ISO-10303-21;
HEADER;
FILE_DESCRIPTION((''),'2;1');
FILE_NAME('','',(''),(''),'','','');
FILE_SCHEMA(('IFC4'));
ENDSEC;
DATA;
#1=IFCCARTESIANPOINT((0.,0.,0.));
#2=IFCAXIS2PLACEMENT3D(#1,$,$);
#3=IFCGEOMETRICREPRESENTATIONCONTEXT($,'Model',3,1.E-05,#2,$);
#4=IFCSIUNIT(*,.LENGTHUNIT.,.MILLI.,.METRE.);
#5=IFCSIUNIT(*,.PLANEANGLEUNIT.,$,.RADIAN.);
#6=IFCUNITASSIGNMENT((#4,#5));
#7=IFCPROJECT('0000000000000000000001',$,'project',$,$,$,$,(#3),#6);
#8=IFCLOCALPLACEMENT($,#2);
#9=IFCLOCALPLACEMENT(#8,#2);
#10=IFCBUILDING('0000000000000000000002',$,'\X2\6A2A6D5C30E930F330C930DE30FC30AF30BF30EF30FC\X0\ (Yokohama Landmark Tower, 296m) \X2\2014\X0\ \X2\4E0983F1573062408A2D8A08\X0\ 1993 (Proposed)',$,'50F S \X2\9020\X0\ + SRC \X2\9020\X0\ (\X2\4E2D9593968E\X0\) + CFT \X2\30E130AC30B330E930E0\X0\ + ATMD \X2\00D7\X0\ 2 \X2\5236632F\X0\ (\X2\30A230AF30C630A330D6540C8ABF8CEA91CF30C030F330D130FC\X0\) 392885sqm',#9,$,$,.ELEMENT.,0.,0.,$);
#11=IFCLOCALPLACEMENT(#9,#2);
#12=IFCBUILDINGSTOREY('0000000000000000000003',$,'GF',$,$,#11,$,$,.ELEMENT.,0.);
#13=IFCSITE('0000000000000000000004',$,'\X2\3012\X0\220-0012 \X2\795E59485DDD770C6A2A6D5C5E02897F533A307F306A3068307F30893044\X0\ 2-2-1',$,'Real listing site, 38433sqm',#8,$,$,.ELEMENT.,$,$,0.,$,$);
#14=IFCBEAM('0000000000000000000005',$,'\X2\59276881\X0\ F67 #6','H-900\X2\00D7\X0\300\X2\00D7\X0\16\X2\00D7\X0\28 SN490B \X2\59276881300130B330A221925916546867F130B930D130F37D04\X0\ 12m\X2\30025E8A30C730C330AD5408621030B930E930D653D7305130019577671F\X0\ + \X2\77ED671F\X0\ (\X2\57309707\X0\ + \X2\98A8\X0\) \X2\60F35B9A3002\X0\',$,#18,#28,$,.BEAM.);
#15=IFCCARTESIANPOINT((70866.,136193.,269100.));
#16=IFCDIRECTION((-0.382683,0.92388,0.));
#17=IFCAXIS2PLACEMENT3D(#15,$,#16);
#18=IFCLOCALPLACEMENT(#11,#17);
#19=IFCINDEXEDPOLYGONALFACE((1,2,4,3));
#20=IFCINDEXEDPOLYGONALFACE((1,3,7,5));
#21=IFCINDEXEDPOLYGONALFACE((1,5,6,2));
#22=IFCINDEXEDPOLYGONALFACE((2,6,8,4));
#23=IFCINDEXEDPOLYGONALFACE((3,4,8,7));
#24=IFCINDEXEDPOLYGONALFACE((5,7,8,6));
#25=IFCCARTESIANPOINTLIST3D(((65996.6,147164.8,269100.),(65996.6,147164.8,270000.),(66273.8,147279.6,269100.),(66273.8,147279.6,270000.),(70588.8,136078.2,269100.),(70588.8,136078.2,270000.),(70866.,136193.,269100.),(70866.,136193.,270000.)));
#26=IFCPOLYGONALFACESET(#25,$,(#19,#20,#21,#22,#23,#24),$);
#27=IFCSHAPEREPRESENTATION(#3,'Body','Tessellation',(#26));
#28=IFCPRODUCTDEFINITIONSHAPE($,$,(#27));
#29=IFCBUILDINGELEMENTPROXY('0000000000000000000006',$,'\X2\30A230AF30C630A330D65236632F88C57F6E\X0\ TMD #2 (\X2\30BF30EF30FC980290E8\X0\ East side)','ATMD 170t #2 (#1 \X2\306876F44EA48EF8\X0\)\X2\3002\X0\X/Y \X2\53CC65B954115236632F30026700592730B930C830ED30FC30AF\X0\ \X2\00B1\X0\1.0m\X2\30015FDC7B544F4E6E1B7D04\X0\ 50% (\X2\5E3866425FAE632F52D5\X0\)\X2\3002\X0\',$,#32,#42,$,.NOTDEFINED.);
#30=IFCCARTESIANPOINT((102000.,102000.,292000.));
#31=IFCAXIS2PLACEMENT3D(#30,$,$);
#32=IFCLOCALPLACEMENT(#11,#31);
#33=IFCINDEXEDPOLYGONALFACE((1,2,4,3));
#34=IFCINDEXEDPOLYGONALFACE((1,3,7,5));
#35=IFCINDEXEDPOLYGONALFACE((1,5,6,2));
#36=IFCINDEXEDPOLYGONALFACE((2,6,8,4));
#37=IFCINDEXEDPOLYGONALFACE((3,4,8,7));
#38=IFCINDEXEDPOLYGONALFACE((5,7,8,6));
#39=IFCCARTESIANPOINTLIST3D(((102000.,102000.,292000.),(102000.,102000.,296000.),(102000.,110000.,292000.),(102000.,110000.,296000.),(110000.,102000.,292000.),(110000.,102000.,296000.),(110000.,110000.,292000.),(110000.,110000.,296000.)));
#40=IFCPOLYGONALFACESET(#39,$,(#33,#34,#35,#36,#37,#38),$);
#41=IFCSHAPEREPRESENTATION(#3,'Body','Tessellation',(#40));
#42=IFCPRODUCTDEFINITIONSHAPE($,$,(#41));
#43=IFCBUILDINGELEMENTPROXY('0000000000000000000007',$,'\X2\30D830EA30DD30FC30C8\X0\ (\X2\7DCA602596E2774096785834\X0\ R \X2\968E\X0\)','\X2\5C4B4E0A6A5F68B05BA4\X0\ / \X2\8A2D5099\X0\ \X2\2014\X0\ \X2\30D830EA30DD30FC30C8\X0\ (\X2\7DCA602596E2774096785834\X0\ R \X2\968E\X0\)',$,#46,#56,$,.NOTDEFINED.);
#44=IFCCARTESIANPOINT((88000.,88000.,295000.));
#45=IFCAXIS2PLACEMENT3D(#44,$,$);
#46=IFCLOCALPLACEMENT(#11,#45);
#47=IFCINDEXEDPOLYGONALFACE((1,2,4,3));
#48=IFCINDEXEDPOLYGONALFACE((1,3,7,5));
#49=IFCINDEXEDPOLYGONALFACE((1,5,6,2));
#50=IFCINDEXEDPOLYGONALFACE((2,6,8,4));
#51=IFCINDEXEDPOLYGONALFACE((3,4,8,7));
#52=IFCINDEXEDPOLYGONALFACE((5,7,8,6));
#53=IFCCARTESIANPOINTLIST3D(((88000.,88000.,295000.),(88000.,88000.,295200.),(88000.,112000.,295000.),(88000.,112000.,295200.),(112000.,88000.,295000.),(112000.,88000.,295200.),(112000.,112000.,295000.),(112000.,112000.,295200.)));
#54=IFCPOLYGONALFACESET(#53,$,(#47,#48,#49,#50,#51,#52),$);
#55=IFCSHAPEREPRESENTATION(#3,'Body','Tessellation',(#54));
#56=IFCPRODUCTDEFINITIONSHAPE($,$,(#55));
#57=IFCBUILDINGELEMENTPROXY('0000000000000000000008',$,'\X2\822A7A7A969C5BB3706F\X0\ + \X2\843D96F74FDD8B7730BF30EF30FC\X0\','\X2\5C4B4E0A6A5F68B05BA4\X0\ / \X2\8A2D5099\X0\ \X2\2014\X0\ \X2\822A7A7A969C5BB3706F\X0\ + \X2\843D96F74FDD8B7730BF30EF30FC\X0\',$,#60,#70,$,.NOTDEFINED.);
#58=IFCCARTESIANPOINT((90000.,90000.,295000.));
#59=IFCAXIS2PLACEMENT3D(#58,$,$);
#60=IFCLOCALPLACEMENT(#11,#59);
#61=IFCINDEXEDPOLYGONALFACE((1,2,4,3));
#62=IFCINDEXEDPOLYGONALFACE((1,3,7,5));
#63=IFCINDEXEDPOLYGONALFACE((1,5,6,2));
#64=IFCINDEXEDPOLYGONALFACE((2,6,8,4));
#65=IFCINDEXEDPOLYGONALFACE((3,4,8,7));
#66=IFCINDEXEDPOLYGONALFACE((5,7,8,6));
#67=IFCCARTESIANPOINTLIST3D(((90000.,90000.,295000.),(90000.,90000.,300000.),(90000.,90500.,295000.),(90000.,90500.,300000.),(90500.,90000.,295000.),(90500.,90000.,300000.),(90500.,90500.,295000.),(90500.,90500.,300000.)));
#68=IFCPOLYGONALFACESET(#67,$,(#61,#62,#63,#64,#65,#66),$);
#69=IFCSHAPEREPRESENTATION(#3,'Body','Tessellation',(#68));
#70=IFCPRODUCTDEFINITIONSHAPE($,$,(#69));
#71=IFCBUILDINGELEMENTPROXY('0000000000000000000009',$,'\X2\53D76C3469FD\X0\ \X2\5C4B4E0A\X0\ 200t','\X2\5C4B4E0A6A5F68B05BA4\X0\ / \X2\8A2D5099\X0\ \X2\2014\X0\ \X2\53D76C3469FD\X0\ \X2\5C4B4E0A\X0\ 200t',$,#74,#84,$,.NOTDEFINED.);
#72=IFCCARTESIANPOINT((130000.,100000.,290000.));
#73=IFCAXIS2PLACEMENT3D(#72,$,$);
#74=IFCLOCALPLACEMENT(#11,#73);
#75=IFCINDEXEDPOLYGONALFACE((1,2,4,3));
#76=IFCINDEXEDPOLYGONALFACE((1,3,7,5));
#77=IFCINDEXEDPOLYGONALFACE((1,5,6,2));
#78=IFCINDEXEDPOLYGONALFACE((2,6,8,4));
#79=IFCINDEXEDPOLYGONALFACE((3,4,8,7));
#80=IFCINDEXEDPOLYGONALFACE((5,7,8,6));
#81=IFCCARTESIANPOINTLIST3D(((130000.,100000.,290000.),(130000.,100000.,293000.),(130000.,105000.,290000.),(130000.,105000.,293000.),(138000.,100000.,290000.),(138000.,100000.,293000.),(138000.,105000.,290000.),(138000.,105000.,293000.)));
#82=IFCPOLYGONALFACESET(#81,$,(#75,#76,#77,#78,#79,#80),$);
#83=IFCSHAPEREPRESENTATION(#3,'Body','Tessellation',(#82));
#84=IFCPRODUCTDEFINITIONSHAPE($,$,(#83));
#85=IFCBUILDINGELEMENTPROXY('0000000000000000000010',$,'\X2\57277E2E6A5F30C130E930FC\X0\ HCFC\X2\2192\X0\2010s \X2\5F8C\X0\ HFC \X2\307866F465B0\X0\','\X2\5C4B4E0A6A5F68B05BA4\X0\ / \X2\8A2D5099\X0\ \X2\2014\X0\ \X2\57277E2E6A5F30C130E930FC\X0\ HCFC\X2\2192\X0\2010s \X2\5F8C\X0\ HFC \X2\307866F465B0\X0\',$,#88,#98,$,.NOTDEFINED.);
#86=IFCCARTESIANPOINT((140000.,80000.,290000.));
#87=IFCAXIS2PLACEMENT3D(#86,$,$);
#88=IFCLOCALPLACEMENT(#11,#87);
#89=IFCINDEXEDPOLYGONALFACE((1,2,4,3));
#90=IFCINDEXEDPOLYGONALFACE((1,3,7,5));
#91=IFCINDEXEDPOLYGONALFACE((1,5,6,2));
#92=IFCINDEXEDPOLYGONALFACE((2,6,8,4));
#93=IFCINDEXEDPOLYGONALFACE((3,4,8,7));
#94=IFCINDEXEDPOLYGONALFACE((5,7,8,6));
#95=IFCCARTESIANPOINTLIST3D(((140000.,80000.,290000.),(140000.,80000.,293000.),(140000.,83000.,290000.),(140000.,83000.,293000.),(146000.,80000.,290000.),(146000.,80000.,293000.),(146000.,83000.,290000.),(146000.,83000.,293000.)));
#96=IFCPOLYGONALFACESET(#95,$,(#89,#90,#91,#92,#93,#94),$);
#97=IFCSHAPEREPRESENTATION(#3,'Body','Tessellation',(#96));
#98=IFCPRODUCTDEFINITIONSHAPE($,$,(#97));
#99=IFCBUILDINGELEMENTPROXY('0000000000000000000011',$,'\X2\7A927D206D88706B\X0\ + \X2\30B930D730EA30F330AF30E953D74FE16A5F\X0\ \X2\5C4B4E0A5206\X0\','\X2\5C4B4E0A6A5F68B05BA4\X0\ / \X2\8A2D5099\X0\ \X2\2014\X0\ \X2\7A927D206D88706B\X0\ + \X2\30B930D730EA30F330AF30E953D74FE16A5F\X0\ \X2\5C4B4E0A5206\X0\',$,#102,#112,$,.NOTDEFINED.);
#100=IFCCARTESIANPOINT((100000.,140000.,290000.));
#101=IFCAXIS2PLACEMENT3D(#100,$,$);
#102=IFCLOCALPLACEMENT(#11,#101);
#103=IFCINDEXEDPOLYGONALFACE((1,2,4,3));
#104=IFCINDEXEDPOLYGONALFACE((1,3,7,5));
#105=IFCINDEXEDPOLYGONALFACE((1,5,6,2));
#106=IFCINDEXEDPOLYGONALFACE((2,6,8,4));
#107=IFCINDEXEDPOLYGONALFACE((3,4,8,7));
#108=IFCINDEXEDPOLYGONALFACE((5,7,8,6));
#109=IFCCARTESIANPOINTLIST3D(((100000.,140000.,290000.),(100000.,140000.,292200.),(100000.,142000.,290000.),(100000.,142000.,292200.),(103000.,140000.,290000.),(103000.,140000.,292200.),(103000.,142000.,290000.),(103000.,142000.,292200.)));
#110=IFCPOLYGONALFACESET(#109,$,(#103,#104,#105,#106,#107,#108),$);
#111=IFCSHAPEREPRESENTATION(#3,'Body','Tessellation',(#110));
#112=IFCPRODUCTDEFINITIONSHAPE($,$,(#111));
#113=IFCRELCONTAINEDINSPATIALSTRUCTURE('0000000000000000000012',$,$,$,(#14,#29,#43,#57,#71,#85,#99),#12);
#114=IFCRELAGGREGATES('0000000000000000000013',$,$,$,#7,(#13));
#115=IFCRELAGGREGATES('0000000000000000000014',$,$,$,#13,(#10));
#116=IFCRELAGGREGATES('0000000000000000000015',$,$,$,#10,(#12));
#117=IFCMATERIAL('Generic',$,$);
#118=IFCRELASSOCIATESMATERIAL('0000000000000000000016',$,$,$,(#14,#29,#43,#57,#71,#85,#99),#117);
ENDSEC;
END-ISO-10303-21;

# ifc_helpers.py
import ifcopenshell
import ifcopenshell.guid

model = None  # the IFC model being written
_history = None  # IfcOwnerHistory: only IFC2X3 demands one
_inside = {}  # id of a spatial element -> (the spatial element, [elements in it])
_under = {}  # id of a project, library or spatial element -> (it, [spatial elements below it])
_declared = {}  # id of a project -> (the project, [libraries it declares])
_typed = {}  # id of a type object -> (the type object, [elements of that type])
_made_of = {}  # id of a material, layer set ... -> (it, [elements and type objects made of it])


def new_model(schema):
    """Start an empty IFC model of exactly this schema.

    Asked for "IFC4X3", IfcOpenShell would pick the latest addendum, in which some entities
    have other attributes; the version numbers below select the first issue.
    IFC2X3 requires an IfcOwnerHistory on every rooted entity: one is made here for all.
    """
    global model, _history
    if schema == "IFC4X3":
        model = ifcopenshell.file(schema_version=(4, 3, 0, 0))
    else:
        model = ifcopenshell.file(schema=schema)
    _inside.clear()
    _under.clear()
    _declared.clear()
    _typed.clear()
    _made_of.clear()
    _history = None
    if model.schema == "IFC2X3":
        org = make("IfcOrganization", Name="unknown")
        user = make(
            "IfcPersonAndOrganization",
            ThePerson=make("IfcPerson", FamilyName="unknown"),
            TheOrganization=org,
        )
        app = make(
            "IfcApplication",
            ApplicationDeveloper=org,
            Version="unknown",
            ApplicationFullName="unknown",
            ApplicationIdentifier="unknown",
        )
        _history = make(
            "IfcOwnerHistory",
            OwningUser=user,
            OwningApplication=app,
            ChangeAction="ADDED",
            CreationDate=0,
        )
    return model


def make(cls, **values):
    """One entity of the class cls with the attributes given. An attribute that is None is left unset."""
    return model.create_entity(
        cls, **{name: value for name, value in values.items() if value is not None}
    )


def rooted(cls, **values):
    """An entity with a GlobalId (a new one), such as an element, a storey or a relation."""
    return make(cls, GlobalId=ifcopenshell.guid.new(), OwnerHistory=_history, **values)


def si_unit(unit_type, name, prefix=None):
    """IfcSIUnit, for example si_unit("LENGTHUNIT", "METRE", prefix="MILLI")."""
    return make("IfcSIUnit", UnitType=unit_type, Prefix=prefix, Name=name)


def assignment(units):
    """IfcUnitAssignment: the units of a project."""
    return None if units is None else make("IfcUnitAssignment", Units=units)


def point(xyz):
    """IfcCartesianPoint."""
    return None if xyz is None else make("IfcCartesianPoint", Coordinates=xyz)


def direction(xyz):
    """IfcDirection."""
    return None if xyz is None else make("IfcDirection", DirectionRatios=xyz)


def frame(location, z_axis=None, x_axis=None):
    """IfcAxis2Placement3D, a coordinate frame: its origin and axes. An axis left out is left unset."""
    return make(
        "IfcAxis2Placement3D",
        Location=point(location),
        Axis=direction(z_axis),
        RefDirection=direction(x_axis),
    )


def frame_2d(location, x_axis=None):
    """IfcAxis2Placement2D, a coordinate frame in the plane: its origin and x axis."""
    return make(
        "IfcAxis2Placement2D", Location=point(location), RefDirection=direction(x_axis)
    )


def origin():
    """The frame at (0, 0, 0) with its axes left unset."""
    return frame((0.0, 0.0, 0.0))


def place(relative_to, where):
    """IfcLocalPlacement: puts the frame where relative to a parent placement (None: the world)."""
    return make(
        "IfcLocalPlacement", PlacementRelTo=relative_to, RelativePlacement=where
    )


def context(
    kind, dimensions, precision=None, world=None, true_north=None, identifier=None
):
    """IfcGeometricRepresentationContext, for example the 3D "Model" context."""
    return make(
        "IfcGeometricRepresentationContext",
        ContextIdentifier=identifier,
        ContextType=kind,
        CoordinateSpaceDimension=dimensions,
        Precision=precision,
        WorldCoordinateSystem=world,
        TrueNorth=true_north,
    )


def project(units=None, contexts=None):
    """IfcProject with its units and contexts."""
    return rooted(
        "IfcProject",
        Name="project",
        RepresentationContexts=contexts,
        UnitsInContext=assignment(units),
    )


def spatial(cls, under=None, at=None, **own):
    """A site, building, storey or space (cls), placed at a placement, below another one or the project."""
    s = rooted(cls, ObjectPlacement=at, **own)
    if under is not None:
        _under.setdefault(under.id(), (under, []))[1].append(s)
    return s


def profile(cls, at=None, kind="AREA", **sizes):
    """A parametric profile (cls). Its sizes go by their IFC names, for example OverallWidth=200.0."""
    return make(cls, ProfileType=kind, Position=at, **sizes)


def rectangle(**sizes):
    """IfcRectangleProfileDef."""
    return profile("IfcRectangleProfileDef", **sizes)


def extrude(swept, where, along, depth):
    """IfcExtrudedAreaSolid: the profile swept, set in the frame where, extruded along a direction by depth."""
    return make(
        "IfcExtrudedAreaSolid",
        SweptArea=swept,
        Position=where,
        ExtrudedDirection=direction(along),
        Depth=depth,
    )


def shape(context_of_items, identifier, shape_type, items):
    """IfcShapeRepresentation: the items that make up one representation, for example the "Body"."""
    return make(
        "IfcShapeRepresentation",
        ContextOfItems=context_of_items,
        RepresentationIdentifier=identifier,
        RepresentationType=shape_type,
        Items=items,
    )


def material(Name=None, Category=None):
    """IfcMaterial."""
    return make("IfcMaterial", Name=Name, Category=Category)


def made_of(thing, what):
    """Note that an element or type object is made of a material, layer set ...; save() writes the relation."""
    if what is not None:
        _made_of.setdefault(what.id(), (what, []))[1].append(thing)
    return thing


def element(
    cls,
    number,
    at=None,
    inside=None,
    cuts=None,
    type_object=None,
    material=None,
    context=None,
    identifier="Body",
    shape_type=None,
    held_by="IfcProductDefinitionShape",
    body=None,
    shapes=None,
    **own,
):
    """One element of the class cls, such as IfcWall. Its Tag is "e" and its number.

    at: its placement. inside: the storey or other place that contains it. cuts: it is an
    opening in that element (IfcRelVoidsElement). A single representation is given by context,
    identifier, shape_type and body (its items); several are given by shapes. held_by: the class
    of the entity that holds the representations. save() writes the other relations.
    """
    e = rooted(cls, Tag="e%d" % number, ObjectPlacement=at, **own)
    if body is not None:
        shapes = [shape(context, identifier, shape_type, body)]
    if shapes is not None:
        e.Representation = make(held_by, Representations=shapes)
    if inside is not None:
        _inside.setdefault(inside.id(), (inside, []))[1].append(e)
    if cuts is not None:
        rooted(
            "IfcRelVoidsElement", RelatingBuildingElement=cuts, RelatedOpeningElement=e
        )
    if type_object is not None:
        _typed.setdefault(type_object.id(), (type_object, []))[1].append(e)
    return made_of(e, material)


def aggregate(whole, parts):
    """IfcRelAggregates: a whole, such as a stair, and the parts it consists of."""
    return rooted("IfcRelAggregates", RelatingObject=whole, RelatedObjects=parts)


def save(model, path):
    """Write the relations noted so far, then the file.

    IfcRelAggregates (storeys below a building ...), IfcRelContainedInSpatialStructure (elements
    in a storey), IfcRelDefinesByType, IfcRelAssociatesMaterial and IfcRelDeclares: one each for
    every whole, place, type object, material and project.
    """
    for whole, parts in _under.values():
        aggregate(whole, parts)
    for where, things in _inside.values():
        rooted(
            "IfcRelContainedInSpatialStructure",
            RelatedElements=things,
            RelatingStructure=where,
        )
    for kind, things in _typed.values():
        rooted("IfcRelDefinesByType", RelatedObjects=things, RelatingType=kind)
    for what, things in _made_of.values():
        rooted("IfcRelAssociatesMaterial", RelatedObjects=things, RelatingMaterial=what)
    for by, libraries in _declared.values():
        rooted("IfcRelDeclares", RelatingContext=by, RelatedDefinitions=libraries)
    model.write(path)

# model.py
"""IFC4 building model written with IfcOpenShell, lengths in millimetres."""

from ifc_helpers import new_model, si_unit, frame, frame_2d, origin, place, context, project, spatial, rectangle, extrude, material, element, save


model = new_model("IFC4")

# Units and contexts
model_context = context("Model", 3, precision=1e-05, world=origin())
ifc_project = project(units=[si_unit("LENGTHUNIT", "METRE", prefix="MILLI"), si_unit("PLANEANGLEUNIT", "RADIAN")], contexts=[model_context])

# Site, building, storey
site_placement = place(None, origin())
site = spatial("IfcSite", under=ifc_project, at=site_placement, Name="〒220-0012 神奈川県横浜市西区みなとみらい 2-2-1", ObjectType="Real listing site, 38433sqm", CompositionType="ELEMENT", RefElevation=0.0)
building_placement = place(site_placement, origin())
building = spatial("IfcBuilding", under=site, at=building_placement, Name="横浜ランドマークタワー (Yokohama Landmark Tower, 296m) — 三菱地所設計 1993 (Proposed)", ObjectType="50F S 造 + SRC 造 (中間階) + CFT メガコラム + ATMD × 2 制振 (アクティブ同調質量ダンパー) 392885sqm", CompositionType="ELEMENT", ElevationOfRefHeight=0.0, ElevationOfTerrain=0.0)
storey_placement = place(building_placement, origin())
storey = spatial("IfcBuildingStorey", under=building, at=storey_placement, Name="GF", CompositionType="ELEMENT", Elevation=0.0)

# Beam
ifc_material_1 = material(Name="Generic")
beam_1_placement = place(storey_placement, frame((70866.0, 136193.0, 269100.0), x_axis=(-0.382683, 0.92388, 0.0)))
element("IfcBeam", 1, at=beam_1_placement, inside=storey, material=ifc_material_1, Name="大梁 F67 #6", Description="H-900×300×16×28 SN490B 大梁、コア→外周柱スパン約 12m。床デッキ合成スラブ受け、長期 + 短期 (地震 + 風) 想定。", PredefinedType="BEAM", context=model_context, shape_type="SweptSolid", body=[
    extrude(rectangle(XDim=12000.0, YDim=300.0, at=frame_2d((6000.0, 150.0))), frame((70866.0, 136193.0, 269100.0), x_axis=(-0.382683, 0.92388, 0.0)), (0.0, 0.0, 1.0), 900.0),
])

# Building element proxies
proxy_1_placement = place(storey_placement, frame((102000.0, 102000.0, 292000.0)))
element("IfcBuildingElementProxy", 2, at=proxy_1_placement, inside=storey, material=ifc_material_1, Name="アクティブ制振装置 TMD #2 (タワー頂部 East side)", Description="ATMD 170t #2 (#1 と直交軸)。X/Y 双方向制振。最大ストローク ±1.0m、応答低減約 50% (常時微振動)。", PredefinedType="NOTDEFINED", context=model_context, shape_type="SweptSolid", body=[
    extrude(rectangle(XDim=8000.0, YDim=8000.0, at=frame_2d((4000.0, 4000.0))), frame((102000.0, 102000.0, 292000.0)), (0.0, 0.0, 1.0), 4000.0),
])
proxy_2_placement = place(storey_placement, frame((88000.0, 88000.0, 295000.0)))
element("IfcBuildingElementProxy", 3, at=proxy_2_placement, inside=storey, material=ifc_material_1, Name="ヘリポート (緊急離着陸場 R 階)", Description="屋上機械室 / 設備 — ヘリポート (緊急離着陸場 R 階)", PredefinedType="NOTDEFINED", context=model_context, shape_type="SweptSolid", body=[
    extrude(rectangle(XDim=24000.0, YDim=24000.0, at=frame_2d((12000.0, 12000.0))), frame((88000.0, 88000.0, 295000.0)), (0.0, 0.0, 1.0), 200.0),
])
proxy_3_placement = place(storey_placement, frame((90000.0, 90000.0, 295000.0)))
element("IfcBuildingElementProxy", 4, at=proxy_3_placement, inside=storey, material=ifc_material_1, Name="航空障害灯 + 落雷保護タワー", Description="屋上機械室 / 設備 — 航空障害灯 + 落雷保護タワー", PredefinedType="NOTDEFINED", context=model_context, shape_type="SweptSolid", body=[
    extrude(rectangle(XDim=500.0, YDim=500.0, at=frame_2d((250.0, 250.0))), frame((90000.0, 90000.0, 295000.0)), (0.0, 0.0, 1.0), 5000.0),
])
proxy_4_placement = place(storey_placement, frame((130000.0, 100000.0, 290000.0)))
element("IfcBuildingElementProxy", 5, at=proxy_4_placement, inside=storey, material=ifc_material_1, Name="受水槽 屋上 200t", Description="屋上機械室 / 設備 — 受水槽 屋上 200t", PredefinedType="NOTDEFINED", context=model_context, shape_type="SweptSolid", body=[
    extrude(rectangle(XDim=8000.0, YDim=5000.0, at=frame_2d((4000.0, 2500.0))), frame((130000.0, 100000.0, 290000.0)), (0.0, 0.0, 1.0), 3000.0),
])
proxy_5_placement = place(storey_placement, frame((140000.0, 80000.0, 290000.0)))
element("IfcBuildingElementProxy", 6, at=proxy_5_placement, inside=storey, material=ifc_material_1, Name="圧縮機チラー HCFC→2010s 後 HFC へ更新", Description="屋上機械室 / 設備 — 圧縮機チラー HCFC→2010s 後 HFC へ更新", PredefinedType="NOTDEFINED", context=model_context, shape_type="SweptSolid", body=[
    extrude(rectangle(XDim=6000.0, YDim=3000.0, at=frame_2d((3000.0, 1500.0))), frame((140000.0, 80000.0, 290000.0)), (0.0, 0.0, 1.0), 3000.0),
])
proxy_6_placement = place(storey_placement, frame((100000.0, 140000.0, 290000.0)))
element("IfcBuildingElementProxy", 7, at=proxy_6_placement, inside=storey, material=ifc_material_1, Name="窒素消火 + スプリンクラ受信機 屋上分", Description="屋上機械室 / 設備 — 窒素消火 + スプリンクラ受信機 屋上分", PredefinedType="NOTDEFINED", context=model_context, shape_type="SweptSolid", body=[
    extrude(rectangle(XDim=3000.0, YDim=2000.0, at=frame_2d((1500.0, 1000.0))), frame((100000.0, 140000.0, 290000.0)), (0.0, 0.0, 1.0), 2200.0),
])

save(model, "model.ifc")
